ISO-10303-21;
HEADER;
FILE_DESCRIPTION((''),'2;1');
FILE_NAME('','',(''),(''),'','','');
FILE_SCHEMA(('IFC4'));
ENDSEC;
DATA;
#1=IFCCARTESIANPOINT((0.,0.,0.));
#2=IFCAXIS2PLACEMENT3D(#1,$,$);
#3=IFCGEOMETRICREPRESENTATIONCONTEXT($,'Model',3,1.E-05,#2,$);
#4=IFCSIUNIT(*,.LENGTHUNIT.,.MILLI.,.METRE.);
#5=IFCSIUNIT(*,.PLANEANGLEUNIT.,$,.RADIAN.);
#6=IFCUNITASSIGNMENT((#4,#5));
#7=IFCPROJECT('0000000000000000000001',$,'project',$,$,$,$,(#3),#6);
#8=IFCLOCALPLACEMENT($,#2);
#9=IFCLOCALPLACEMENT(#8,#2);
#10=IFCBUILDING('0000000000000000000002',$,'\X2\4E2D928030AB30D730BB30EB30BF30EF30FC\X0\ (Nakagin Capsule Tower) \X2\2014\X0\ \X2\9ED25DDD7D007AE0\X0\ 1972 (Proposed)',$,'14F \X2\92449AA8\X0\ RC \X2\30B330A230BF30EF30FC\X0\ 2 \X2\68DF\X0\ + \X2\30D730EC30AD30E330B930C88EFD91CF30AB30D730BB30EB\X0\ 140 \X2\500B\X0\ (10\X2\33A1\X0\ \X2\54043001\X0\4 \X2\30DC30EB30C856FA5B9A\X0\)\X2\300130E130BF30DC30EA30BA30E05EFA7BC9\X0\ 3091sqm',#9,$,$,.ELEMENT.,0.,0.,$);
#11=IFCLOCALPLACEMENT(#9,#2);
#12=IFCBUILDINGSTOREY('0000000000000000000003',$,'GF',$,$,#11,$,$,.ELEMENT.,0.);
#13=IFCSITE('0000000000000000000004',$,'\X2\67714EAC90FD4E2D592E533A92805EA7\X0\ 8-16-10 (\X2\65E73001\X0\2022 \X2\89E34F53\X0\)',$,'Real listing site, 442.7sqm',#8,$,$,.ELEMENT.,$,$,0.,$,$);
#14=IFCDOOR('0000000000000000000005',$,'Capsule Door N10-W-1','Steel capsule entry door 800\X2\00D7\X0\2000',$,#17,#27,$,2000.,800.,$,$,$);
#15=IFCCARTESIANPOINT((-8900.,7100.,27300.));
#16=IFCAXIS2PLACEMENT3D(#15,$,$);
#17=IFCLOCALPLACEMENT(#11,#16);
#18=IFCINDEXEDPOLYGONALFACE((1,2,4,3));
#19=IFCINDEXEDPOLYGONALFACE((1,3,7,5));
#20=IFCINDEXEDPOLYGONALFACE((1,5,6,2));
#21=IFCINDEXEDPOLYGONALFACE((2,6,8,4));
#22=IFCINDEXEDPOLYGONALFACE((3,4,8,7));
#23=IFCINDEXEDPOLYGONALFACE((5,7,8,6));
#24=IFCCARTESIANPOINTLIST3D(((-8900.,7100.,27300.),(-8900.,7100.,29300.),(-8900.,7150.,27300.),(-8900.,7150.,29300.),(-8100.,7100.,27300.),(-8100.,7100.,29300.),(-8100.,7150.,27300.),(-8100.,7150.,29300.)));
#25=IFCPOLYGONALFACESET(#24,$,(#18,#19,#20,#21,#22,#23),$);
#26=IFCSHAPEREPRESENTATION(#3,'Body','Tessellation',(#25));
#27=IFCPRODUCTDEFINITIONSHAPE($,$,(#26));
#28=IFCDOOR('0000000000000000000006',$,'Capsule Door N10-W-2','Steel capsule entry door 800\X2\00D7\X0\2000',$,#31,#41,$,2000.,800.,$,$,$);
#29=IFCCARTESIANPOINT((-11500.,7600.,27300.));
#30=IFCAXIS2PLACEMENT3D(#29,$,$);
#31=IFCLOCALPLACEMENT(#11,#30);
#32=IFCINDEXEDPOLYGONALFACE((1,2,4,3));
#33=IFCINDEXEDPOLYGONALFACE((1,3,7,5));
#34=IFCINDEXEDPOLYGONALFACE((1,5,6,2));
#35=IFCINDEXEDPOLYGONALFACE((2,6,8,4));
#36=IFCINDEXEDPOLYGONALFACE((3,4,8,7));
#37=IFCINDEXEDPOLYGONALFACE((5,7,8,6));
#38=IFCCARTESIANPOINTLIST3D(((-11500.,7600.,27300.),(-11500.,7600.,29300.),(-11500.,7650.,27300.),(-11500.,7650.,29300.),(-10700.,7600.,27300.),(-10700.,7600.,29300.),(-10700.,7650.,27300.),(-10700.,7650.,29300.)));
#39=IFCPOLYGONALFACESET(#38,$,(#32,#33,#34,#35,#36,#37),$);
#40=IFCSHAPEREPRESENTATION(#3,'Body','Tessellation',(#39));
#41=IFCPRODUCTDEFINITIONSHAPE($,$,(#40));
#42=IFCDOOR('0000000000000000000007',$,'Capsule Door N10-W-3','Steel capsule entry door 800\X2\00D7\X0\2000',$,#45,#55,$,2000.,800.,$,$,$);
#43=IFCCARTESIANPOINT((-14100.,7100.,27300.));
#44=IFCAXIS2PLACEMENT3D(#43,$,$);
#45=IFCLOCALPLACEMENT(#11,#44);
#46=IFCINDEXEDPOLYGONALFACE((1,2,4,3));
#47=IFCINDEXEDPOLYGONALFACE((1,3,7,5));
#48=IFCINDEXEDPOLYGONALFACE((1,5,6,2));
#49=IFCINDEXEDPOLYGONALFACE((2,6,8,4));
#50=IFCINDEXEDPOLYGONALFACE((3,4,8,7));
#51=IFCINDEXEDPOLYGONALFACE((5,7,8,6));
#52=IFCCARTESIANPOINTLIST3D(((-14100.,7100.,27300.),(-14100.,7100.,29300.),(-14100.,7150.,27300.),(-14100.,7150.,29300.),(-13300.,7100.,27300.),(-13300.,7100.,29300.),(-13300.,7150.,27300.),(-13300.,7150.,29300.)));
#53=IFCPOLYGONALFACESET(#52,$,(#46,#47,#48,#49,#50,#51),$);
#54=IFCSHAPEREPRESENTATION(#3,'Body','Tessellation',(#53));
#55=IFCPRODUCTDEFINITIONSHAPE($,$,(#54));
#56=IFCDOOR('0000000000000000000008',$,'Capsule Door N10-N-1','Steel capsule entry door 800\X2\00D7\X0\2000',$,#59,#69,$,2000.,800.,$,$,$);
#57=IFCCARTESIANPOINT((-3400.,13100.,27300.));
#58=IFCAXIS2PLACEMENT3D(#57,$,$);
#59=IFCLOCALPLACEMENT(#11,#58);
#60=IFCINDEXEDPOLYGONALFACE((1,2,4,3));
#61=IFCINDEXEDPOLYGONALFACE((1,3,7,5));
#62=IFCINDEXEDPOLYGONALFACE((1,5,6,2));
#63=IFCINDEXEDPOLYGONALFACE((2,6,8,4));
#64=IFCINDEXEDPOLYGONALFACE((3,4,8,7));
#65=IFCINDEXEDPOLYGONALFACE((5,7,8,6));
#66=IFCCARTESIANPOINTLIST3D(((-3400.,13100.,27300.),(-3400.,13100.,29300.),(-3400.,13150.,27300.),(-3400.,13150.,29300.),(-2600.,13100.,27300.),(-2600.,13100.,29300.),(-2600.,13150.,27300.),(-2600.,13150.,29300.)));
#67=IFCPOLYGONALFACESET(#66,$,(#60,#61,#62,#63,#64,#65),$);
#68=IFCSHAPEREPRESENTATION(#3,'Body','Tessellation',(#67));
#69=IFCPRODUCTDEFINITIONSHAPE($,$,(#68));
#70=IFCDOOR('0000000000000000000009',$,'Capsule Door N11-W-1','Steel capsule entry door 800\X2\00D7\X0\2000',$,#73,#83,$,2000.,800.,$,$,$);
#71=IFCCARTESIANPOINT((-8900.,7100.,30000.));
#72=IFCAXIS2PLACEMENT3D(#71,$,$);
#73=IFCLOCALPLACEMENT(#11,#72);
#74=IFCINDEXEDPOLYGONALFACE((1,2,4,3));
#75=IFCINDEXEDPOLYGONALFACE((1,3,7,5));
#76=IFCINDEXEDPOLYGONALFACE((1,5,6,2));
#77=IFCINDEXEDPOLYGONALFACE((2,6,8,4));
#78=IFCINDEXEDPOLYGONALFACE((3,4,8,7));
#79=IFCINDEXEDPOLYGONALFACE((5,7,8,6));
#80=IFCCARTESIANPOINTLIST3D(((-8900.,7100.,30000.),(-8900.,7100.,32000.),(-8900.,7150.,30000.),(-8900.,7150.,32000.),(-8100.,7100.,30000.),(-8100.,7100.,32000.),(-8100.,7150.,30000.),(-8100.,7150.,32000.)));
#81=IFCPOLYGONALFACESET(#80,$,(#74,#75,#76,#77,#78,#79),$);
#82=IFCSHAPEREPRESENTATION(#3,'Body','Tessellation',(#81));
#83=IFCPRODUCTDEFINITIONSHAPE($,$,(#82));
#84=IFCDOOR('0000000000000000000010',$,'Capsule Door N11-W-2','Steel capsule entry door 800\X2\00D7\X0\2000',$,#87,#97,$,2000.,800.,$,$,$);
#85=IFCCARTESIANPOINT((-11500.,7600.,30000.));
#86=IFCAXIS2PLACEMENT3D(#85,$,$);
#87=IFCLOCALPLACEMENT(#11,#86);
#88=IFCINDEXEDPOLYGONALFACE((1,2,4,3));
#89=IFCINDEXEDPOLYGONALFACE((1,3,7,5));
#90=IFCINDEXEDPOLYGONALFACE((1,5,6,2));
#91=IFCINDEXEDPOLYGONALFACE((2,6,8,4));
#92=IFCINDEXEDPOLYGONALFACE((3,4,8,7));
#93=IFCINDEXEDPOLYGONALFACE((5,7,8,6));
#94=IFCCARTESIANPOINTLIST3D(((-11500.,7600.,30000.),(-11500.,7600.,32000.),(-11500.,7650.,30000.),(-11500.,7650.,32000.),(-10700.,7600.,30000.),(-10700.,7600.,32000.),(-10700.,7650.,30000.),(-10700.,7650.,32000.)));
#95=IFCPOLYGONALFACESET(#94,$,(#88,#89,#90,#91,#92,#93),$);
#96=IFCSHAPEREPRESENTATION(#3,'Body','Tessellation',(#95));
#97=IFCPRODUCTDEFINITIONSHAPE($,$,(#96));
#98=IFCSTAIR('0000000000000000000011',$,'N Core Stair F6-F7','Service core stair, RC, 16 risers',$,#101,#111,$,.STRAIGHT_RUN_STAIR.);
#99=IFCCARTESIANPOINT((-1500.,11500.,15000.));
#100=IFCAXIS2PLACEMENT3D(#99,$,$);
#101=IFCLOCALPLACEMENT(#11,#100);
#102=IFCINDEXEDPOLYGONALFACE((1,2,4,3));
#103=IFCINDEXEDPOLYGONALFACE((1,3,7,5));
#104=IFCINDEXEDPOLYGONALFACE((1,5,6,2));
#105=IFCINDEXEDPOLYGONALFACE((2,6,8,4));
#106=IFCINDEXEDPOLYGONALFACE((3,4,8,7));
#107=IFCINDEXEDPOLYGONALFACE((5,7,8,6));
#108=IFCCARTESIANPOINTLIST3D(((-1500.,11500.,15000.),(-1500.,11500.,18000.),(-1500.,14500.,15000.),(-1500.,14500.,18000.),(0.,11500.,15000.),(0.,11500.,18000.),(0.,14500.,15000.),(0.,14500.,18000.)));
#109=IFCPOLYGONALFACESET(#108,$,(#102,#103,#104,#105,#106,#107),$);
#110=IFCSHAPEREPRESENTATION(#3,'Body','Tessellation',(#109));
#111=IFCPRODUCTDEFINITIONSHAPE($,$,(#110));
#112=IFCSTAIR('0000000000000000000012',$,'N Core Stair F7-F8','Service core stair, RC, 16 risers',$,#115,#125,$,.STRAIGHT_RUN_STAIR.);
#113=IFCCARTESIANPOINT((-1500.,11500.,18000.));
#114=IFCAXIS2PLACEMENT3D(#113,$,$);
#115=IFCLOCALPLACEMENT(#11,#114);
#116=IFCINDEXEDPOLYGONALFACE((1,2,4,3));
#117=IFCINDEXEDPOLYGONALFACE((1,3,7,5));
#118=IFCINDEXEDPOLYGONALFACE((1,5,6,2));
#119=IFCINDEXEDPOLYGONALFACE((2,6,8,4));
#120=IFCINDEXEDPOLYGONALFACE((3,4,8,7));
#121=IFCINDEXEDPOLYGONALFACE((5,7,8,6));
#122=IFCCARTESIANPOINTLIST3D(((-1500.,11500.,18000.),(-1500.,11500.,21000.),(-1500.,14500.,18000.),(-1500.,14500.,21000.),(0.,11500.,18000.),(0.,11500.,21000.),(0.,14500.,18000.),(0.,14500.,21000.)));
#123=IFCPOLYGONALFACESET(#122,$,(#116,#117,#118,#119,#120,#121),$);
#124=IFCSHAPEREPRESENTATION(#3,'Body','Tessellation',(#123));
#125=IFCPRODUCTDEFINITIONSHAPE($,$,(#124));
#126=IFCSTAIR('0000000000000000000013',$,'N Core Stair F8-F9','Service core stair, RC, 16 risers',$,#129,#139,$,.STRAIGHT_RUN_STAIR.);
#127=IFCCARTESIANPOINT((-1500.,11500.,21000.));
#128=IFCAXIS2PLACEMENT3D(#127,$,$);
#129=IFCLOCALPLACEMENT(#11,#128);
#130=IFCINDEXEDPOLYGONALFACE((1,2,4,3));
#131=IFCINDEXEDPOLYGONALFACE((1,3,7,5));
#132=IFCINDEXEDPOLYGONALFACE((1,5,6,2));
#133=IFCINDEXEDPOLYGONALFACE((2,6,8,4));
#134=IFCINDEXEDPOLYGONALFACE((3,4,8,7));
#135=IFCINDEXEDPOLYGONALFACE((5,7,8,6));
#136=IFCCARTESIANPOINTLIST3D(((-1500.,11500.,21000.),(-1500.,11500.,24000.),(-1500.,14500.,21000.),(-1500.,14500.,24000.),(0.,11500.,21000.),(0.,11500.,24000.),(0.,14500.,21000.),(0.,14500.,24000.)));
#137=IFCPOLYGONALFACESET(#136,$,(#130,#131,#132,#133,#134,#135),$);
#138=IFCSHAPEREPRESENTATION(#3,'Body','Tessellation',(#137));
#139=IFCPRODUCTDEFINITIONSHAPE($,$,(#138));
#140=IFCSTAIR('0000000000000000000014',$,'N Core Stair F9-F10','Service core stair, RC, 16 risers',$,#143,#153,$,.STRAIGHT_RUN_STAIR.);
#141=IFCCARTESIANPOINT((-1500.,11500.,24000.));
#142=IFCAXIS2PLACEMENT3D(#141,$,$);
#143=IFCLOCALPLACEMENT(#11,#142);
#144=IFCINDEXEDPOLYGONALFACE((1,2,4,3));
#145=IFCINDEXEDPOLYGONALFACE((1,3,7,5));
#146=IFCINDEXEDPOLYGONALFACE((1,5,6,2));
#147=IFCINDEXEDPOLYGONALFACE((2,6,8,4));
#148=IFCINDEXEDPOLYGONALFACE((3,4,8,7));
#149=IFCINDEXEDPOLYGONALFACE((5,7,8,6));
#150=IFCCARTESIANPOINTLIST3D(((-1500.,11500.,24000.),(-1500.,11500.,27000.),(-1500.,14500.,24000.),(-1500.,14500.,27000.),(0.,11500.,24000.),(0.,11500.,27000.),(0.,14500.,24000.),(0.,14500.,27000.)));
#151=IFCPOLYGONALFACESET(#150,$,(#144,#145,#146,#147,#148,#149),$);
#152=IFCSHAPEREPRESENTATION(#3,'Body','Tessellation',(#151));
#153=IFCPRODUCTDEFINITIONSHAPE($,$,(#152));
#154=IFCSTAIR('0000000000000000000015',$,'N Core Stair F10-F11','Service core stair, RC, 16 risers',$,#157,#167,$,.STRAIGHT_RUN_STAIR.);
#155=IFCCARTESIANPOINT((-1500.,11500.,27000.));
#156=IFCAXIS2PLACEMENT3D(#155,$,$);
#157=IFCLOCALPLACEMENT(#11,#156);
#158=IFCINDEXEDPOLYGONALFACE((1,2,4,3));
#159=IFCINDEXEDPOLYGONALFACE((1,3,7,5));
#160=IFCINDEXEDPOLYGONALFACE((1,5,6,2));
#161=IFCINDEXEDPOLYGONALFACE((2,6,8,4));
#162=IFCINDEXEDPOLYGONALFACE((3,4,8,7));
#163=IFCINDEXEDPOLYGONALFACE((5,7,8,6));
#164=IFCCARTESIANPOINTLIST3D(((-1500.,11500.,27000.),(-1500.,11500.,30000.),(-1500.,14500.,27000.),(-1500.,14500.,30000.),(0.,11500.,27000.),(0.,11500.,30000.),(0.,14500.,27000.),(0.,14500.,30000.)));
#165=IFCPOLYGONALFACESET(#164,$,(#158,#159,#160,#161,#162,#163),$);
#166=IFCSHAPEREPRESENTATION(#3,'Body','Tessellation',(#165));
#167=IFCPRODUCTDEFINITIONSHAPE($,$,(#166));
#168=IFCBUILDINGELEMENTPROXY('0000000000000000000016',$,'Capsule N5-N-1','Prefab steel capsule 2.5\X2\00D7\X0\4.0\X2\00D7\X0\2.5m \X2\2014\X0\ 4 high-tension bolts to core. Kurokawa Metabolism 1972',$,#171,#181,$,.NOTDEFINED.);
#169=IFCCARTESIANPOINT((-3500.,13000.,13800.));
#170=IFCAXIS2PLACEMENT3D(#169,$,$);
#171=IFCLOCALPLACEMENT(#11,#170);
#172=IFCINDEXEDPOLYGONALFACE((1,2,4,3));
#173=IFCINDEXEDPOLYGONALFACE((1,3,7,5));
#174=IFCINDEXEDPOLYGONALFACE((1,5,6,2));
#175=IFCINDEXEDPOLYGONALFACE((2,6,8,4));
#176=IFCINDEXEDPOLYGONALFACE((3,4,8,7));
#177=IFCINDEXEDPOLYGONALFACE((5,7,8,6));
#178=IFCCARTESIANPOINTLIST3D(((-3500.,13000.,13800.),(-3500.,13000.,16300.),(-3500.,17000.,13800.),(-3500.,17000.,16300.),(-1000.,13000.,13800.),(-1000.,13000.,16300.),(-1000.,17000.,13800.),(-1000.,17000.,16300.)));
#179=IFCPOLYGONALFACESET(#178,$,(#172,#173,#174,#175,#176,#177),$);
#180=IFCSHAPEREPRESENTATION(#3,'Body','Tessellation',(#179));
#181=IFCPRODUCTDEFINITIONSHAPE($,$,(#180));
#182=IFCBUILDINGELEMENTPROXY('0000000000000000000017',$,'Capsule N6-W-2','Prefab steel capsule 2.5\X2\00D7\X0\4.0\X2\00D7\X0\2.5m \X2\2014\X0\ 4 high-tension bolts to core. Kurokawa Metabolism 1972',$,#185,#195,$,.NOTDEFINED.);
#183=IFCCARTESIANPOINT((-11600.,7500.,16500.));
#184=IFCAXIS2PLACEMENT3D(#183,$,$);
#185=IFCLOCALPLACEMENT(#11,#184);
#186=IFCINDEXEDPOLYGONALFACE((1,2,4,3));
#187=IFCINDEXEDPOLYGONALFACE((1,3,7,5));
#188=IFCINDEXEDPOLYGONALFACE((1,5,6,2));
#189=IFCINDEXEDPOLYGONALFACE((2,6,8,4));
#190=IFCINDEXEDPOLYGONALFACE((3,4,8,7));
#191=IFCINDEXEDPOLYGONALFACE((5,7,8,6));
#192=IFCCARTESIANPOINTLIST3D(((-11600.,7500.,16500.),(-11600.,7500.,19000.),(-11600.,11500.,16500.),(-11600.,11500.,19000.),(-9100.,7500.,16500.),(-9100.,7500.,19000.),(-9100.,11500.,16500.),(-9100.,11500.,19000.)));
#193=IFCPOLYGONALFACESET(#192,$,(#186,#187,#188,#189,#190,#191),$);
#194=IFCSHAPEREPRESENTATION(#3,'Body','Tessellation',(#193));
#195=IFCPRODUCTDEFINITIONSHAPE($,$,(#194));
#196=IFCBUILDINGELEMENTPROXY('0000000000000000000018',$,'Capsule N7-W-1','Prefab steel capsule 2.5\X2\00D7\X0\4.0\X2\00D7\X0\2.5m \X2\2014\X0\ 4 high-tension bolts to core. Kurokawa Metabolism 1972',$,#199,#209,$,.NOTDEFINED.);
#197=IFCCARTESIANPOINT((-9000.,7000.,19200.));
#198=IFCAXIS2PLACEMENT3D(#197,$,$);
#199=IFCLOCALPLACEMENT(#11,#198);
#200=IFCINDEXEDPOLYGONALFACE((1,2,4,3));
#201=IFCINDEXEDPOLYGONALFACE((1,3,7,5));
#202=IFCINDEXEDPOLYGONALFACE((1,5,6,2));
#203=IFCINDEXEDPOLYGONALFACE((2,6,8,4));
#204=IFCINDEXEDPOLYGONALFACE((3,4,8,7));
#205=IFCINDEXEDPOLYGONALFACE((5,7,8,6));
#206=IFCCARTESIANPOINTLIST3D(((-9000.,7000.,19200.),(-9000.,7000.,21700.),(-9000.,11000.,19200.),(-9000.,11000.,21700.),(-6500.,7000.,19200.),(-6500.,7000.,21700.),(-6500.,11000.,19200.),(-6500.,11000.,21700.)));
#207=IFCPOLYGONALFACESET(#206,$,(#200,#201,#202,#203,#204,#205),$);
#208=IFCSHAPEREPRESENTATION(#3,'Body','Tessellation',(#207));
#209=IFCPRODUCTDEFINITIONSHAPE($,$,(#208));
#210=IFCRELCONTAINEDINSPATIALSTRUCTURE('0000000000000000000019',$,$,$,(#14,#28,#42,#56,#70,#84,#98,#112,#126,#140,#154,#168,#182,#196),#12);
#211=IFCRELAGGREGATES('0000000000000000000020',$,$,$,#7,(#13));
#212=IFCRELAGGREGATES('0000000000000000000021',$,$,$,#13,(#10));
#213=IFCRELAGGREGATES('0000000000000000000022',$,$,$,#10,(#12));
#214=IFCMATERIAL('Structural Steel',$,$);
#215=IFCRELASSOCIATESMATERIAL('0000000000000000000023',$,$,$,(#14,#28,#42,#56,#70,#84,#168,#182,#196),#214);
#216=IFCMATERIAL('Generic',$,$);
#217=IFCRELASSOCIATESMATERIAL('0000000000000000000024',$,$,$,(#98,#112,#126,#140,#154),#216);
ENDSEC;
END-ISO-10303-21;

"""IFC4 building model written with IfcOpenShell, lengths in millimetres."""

from ifc_helpers import new_model, si_unit, frame, frame_2d, origin, place, context, project, spatial, rectangle, extrude, material, element, save


model = new_model("IFC4")

# Units and contexts
model_context = context("Model", 3, precision=1e-05, world=origin())
ifc_project = project(units=[si_unit("LENGTHUNIT", "METRE", prefix="MILLI"), si_unit("PLANEANGLEUNIT", "RADIAN")], contexts=[model_context])

# Site, building, storey
site_placement = place(None, origin())
site = spatial("IfcSite", under=ifc_project, at=site_placement, Name="東京都中央区銀座 8-16-10 (旧、2022 解体)", ObjectType="Real listing site, 442.7sqm", CompositionType="ELEMENT", RefElevation=0.0)
building_placement = place(site_placement, origin())
building = spatial("IfcBuilding", under=site, at=building_placement, Name="中銀カプセルタワー (Nakagin Capsule Tower) — 黒川紀章 1972 (Proposed)", ObjectType="14F 鉄骨 RC コアタワー 2 棟 + プレキャスト軽量カプセル 140 個 (10㎡ 各、4 ボルト固定)、メタボリズム建築 3091sqm", CompositionType="ELEMENT", ElevationOfRefHeight=0.0, ElevationOfTerrain=0.0)
storey_placement = place(building_placement, origin())
storey = spatial("IfcBuildingStorey", under=building, at=storey_placement, Name="GF", CompositionType="ELEMENT", Elevation=0.0)

# Doors
ifc_material_1 = material(Name="Structural Steel")
door_1_placement = place(storey_placement, frame((-8900.0, 7100.0, 27300.0)))
element("IfcDoor", 1, at=door_1_placement, inside=storey, material=ifc_material_1, Name="Capsule Door N10-W-1", Description="Steel capsule entry door 800×2000", OverallHeight=2000.0, OverallWidth=800.0, context=model_context, shape_type="SweptSolid", body=[
    extrude(rectangle(XDim=800.0, YDim=50.0, at=frame_2d((400.0, 25.0))), frame((-8900.0, 7100.0, 27300.0)), (0.0, 0.0, 1.0), 2000.0),
])
door_2_placement = place(storey_placement, frame((-11500.0, 7600.0, 27300.0)))
element("IfcDoor", 2, at=door_2_placement, inside=storey, material=ifc_material_1, Name="Capsule Door N10-W-2", Description="Steel capsule entry door 800×2000", OverallHeight=2000.0, OverallWidth=800.0, context=model_context, shape_type="SweptSolid", body=[
    extrude(rectangle(XDim=800.0, YDim=50.0, at=frame_2d((400.0, 25.0))), frame((-11500.0, 7600.0, 27300.0)), (0.0, 0.0, 1.0), 2000.0),
])
door_3_placement = place(storey_placement, frame((-14100.0, 7100.0, 27300.0)))
element("IfcDoor", 3, at=door_3_placement, inside=storey, material=ifc_material_1, Name="Capsule Door N10-W-3", Description="Steel capsule entry door 800×2000", OverallHeight=2000.0, OverallWidth=800.0, context=model_context, shape_type="SweptSolid", body=[
    extrude(rectangle(XDim=800.0, YDim=50.0, at=frame_2d((400.0, 25.0))), frame((-14100.0, 7100.0, 27300.0)), (0.0, 0.0, 1.0), 2000.0),
])
door_4_placement = place(storey_placement, frame((-3400.0, 13100.0, 27300.0)))
element("IfcDoor", 4, at=door_4_placement, inside=storey, material=ifc_material_1, Name="Capsule Door N10-N-1", Description="Steel capsule entry door 800×2000", OverallHeight=2000.0, OverallWidth=800.0, context=model_context, shape_type="SweptSolid", body=[
    extrude(rectangle(XDim=800.0, YDim=50.0, at=frame_2d((400.0, 25.0))), frame((-3400.0, 13100.0, 27300.0)), (0.0, 0.0, 1.0), 2000.0),
])
door_5_placement = place(storey_placement, frame((-8900.0, 7100.0, 30000.0)))
element("IfcDoor", 5, at=door_5_placement, inside=storey, material=ifc_material_1, Name="Capsule Door N11-W-1", Description="Steel capsule entry door 800×2000", OverallHeight=2000.0, OverallWidth=800.0, context=model_context, shape_type="SweptSolid", body=[
    extrude(rectangle(XDim=800.0, YDim=50.0, at=frame_2d((400.0, 25.0))), frame((-8900.0, 7100.0, 30000.0)), (0.0, 0.0, 1.0), 2000.0),
])
door_6_placement = place(storey_placement, frame((-11500.0, 7600.0, 30000.0)))
element("IfcDoor", 6, at=door_6_placement, inside=storey, material=ifc_material_1, Name="Capsule Door N11-W-2", Description="Steel capsule entry door 800×2000", OverallHeight=2000.0, OverallWidth=800.0, context=model_context, shape_type="SweptSolid", body=[
    extrude(rectangle(XDim=800.0, YDim=50.0, at=frame_2d((400.0, 25.0))), frame((-11500.0, 7600.0, 30000.0)), (0.0, 0.0, 1.0), 2000.0),
])

# Stairs
ifc_material_2 = material(Name="Generic")
stair_1_placement = place(storey_placement, frame((-1500.0, 11500.0, 15000.0)))
element("IfcStair", 7, at=stair_1_placement, inside=storey, material=ifc_material_2, Name="N Core Stair F6-F7", Description="Service core stair, RC, 16 risers", PredefinedType="STRAIGHT_RUN_STAIR", context=model_context, shape_type="SweptSolid", body=[
    extrude(rectangle(XDim=1500.0, YDim=3000.0, at=frame_2d((750.0, 1500.0))), frame((-1500.0, 11500.0, 15000.0)), (0.0, 0.0, 1.0), 3000.0),
])
stair_2_placement = place(storey_placement, frame((-1500.0, 11500.0, 18000.0)))
element("IfcStair", 8, at=stair_2_placement, inside=storey, material=ifc_material_2, Name="N Core Stair F7-F8", Description="Service core stair, RC, 16 risers", PredefinedType="STRAIGHT_RUN_STAIR", context=model_context, shape_type="SweptSolid", body=[
    extrude(rectangle(XDim=1500.0, YDim=3000.0, at=frame_2d((750.0, 1500.0))), frame((-1500.0, 11500.0, 18000.0)), (0.0, 0.0, 1.0), 3000.0),
])
stair_3_placement = place(storey_placement, frame((-1500.0, 11500.0, 21000.0)))
element("IfcStair", 9, at=stair_3_placement, inside=storey, material=ifc_material_2, Name="N Core Stair F8-F9", Description="Service core stair, RC, 16 risers", PredefinedType="STRAIGHT_RUN_STAIR", context=model_context, shape_type="SweptSolid", body=[
    extrude(rectangle(XDim=1500.0, YDim=3000.0, at=frame_2d((750.0, 1500.0))), frame((-1500.0, 11500.0, 21000.0)), (0.0, 0.0, 1.0), 3000.0),
])
stair_4_placement = place(storey_placement, frame((-1500.0, 11500.0, 24000.0)))
element("IfcStair", 10, at=stair_4_placement, inside=storey, material=ifc_material_2, Name="N Core Stair F9-F10", Description="Service core stair, RC, 16 risers", PredefinedType="STRAIGHT_RUN_STAIR", context=model_context, shape_type="SweptSolid", body=[
    extrude(rectangle(XDim=1500.0, YDim=3000.0, at=frame_2d((750.0, 1500.0))), frame((-1500.0, 11500.0, 24000.0)), (0.0, 0.0, 1.0), 3000.0),
])
stair_5_placement = place(storey_placement, frame((-1500.0, 11500.0, 27000.0)))
element("IfcStair", 11, at=stair_5_placement, inside=storey, material=ifc_material_2, Name="N Core Stair F10-F11", Description="Service core stair, RC, 16 risers", PredefinedType="STRAIGHT_RUN_STAIR", context=model_context, shape_type="SweptSolid", body=[
    extrude(rectangle(XDim=1500.0, YDim=3000.0, at=frame_2d((750.0, 1500.0))), frame((-1500.0, 11500.0, 27000.0)), (0.0, 0.0, 1.0), 3000.0),
])

# Building element proxies
proxy_1_placement = place(storey_placement, frame((-3500.0, 13000.0, 13800.0)))
element("IfcBuildingElementProxy", 12, at=proxy_1_placement, inside=storey, material=ifc_material_1, Name="Capsule N5-N-1", Description="Prefab steel capsule 2.5×4.0×2.5m — 4 high-tension bolts to core. Kurokawa Metabolism 1972", PredefinedType="NOTDEFINED", context=model_context, shape_type="SweptSolid", body=[
    extrude(rectangle(XDim=2500.0, YDim=4000.0, at=frame_2d((1250.0, 2000.0))), frame((-3500.0, 13000.0, 13800.0)), (0.0, 0.0, 1.0), 2500.0),
])
proxy_2_placement = place(storey_placement, frame((-11600.0, 7500.0, 16500.0)))
element("IfcBuildingElementProxy", 13, at=proxy_2_placement, inside=storey, material=ifc_material_1, Name="Capsule N6-W-2", Description="Prefab steel capsule 2.5×4.0×2.5m — 4 high-tension bolts to core. Kurokawa Metabolism 1972", PredefinedType="NOTDEFINED", context=model_context, shape_type="SweptSolid", body=[
    extrude(rectangle(XDim=2500.0, YDim=4000.0, at=frame_2d((1250.0, 2000.0))), frame((-11600.0, 7500.0, 16500.0)), (0.0, 0.0, 1.0), 2500.0),
])
proxy_3_placement = place(storey_placement, frame((-9000.0, 7000.0, 19200.0)))
element("IfcBuildingElementProxy", 14, at=proxy_3_placement, inside=storey, material=ifc_material_1, Name="Capsule N7-W-1", Description="Prefab steel capsule 2.5×4.0×2.5m — 4 high-tension bolts to core. Kurokawa Metabolism 1972", PredefinedType="NOTDEFINED", context=model_context, shape_type="SweptSolid", body=[
    extrude(rectangle(XDim=2500.0, YDim=4000.0, at=frame_2d((1250.0, 2000.0))), frame((-9000.0, 7000.0, 19200.0)), (0.0, 0.0, 1.0), 2500.0),
])

save(model, "model.ifc")
